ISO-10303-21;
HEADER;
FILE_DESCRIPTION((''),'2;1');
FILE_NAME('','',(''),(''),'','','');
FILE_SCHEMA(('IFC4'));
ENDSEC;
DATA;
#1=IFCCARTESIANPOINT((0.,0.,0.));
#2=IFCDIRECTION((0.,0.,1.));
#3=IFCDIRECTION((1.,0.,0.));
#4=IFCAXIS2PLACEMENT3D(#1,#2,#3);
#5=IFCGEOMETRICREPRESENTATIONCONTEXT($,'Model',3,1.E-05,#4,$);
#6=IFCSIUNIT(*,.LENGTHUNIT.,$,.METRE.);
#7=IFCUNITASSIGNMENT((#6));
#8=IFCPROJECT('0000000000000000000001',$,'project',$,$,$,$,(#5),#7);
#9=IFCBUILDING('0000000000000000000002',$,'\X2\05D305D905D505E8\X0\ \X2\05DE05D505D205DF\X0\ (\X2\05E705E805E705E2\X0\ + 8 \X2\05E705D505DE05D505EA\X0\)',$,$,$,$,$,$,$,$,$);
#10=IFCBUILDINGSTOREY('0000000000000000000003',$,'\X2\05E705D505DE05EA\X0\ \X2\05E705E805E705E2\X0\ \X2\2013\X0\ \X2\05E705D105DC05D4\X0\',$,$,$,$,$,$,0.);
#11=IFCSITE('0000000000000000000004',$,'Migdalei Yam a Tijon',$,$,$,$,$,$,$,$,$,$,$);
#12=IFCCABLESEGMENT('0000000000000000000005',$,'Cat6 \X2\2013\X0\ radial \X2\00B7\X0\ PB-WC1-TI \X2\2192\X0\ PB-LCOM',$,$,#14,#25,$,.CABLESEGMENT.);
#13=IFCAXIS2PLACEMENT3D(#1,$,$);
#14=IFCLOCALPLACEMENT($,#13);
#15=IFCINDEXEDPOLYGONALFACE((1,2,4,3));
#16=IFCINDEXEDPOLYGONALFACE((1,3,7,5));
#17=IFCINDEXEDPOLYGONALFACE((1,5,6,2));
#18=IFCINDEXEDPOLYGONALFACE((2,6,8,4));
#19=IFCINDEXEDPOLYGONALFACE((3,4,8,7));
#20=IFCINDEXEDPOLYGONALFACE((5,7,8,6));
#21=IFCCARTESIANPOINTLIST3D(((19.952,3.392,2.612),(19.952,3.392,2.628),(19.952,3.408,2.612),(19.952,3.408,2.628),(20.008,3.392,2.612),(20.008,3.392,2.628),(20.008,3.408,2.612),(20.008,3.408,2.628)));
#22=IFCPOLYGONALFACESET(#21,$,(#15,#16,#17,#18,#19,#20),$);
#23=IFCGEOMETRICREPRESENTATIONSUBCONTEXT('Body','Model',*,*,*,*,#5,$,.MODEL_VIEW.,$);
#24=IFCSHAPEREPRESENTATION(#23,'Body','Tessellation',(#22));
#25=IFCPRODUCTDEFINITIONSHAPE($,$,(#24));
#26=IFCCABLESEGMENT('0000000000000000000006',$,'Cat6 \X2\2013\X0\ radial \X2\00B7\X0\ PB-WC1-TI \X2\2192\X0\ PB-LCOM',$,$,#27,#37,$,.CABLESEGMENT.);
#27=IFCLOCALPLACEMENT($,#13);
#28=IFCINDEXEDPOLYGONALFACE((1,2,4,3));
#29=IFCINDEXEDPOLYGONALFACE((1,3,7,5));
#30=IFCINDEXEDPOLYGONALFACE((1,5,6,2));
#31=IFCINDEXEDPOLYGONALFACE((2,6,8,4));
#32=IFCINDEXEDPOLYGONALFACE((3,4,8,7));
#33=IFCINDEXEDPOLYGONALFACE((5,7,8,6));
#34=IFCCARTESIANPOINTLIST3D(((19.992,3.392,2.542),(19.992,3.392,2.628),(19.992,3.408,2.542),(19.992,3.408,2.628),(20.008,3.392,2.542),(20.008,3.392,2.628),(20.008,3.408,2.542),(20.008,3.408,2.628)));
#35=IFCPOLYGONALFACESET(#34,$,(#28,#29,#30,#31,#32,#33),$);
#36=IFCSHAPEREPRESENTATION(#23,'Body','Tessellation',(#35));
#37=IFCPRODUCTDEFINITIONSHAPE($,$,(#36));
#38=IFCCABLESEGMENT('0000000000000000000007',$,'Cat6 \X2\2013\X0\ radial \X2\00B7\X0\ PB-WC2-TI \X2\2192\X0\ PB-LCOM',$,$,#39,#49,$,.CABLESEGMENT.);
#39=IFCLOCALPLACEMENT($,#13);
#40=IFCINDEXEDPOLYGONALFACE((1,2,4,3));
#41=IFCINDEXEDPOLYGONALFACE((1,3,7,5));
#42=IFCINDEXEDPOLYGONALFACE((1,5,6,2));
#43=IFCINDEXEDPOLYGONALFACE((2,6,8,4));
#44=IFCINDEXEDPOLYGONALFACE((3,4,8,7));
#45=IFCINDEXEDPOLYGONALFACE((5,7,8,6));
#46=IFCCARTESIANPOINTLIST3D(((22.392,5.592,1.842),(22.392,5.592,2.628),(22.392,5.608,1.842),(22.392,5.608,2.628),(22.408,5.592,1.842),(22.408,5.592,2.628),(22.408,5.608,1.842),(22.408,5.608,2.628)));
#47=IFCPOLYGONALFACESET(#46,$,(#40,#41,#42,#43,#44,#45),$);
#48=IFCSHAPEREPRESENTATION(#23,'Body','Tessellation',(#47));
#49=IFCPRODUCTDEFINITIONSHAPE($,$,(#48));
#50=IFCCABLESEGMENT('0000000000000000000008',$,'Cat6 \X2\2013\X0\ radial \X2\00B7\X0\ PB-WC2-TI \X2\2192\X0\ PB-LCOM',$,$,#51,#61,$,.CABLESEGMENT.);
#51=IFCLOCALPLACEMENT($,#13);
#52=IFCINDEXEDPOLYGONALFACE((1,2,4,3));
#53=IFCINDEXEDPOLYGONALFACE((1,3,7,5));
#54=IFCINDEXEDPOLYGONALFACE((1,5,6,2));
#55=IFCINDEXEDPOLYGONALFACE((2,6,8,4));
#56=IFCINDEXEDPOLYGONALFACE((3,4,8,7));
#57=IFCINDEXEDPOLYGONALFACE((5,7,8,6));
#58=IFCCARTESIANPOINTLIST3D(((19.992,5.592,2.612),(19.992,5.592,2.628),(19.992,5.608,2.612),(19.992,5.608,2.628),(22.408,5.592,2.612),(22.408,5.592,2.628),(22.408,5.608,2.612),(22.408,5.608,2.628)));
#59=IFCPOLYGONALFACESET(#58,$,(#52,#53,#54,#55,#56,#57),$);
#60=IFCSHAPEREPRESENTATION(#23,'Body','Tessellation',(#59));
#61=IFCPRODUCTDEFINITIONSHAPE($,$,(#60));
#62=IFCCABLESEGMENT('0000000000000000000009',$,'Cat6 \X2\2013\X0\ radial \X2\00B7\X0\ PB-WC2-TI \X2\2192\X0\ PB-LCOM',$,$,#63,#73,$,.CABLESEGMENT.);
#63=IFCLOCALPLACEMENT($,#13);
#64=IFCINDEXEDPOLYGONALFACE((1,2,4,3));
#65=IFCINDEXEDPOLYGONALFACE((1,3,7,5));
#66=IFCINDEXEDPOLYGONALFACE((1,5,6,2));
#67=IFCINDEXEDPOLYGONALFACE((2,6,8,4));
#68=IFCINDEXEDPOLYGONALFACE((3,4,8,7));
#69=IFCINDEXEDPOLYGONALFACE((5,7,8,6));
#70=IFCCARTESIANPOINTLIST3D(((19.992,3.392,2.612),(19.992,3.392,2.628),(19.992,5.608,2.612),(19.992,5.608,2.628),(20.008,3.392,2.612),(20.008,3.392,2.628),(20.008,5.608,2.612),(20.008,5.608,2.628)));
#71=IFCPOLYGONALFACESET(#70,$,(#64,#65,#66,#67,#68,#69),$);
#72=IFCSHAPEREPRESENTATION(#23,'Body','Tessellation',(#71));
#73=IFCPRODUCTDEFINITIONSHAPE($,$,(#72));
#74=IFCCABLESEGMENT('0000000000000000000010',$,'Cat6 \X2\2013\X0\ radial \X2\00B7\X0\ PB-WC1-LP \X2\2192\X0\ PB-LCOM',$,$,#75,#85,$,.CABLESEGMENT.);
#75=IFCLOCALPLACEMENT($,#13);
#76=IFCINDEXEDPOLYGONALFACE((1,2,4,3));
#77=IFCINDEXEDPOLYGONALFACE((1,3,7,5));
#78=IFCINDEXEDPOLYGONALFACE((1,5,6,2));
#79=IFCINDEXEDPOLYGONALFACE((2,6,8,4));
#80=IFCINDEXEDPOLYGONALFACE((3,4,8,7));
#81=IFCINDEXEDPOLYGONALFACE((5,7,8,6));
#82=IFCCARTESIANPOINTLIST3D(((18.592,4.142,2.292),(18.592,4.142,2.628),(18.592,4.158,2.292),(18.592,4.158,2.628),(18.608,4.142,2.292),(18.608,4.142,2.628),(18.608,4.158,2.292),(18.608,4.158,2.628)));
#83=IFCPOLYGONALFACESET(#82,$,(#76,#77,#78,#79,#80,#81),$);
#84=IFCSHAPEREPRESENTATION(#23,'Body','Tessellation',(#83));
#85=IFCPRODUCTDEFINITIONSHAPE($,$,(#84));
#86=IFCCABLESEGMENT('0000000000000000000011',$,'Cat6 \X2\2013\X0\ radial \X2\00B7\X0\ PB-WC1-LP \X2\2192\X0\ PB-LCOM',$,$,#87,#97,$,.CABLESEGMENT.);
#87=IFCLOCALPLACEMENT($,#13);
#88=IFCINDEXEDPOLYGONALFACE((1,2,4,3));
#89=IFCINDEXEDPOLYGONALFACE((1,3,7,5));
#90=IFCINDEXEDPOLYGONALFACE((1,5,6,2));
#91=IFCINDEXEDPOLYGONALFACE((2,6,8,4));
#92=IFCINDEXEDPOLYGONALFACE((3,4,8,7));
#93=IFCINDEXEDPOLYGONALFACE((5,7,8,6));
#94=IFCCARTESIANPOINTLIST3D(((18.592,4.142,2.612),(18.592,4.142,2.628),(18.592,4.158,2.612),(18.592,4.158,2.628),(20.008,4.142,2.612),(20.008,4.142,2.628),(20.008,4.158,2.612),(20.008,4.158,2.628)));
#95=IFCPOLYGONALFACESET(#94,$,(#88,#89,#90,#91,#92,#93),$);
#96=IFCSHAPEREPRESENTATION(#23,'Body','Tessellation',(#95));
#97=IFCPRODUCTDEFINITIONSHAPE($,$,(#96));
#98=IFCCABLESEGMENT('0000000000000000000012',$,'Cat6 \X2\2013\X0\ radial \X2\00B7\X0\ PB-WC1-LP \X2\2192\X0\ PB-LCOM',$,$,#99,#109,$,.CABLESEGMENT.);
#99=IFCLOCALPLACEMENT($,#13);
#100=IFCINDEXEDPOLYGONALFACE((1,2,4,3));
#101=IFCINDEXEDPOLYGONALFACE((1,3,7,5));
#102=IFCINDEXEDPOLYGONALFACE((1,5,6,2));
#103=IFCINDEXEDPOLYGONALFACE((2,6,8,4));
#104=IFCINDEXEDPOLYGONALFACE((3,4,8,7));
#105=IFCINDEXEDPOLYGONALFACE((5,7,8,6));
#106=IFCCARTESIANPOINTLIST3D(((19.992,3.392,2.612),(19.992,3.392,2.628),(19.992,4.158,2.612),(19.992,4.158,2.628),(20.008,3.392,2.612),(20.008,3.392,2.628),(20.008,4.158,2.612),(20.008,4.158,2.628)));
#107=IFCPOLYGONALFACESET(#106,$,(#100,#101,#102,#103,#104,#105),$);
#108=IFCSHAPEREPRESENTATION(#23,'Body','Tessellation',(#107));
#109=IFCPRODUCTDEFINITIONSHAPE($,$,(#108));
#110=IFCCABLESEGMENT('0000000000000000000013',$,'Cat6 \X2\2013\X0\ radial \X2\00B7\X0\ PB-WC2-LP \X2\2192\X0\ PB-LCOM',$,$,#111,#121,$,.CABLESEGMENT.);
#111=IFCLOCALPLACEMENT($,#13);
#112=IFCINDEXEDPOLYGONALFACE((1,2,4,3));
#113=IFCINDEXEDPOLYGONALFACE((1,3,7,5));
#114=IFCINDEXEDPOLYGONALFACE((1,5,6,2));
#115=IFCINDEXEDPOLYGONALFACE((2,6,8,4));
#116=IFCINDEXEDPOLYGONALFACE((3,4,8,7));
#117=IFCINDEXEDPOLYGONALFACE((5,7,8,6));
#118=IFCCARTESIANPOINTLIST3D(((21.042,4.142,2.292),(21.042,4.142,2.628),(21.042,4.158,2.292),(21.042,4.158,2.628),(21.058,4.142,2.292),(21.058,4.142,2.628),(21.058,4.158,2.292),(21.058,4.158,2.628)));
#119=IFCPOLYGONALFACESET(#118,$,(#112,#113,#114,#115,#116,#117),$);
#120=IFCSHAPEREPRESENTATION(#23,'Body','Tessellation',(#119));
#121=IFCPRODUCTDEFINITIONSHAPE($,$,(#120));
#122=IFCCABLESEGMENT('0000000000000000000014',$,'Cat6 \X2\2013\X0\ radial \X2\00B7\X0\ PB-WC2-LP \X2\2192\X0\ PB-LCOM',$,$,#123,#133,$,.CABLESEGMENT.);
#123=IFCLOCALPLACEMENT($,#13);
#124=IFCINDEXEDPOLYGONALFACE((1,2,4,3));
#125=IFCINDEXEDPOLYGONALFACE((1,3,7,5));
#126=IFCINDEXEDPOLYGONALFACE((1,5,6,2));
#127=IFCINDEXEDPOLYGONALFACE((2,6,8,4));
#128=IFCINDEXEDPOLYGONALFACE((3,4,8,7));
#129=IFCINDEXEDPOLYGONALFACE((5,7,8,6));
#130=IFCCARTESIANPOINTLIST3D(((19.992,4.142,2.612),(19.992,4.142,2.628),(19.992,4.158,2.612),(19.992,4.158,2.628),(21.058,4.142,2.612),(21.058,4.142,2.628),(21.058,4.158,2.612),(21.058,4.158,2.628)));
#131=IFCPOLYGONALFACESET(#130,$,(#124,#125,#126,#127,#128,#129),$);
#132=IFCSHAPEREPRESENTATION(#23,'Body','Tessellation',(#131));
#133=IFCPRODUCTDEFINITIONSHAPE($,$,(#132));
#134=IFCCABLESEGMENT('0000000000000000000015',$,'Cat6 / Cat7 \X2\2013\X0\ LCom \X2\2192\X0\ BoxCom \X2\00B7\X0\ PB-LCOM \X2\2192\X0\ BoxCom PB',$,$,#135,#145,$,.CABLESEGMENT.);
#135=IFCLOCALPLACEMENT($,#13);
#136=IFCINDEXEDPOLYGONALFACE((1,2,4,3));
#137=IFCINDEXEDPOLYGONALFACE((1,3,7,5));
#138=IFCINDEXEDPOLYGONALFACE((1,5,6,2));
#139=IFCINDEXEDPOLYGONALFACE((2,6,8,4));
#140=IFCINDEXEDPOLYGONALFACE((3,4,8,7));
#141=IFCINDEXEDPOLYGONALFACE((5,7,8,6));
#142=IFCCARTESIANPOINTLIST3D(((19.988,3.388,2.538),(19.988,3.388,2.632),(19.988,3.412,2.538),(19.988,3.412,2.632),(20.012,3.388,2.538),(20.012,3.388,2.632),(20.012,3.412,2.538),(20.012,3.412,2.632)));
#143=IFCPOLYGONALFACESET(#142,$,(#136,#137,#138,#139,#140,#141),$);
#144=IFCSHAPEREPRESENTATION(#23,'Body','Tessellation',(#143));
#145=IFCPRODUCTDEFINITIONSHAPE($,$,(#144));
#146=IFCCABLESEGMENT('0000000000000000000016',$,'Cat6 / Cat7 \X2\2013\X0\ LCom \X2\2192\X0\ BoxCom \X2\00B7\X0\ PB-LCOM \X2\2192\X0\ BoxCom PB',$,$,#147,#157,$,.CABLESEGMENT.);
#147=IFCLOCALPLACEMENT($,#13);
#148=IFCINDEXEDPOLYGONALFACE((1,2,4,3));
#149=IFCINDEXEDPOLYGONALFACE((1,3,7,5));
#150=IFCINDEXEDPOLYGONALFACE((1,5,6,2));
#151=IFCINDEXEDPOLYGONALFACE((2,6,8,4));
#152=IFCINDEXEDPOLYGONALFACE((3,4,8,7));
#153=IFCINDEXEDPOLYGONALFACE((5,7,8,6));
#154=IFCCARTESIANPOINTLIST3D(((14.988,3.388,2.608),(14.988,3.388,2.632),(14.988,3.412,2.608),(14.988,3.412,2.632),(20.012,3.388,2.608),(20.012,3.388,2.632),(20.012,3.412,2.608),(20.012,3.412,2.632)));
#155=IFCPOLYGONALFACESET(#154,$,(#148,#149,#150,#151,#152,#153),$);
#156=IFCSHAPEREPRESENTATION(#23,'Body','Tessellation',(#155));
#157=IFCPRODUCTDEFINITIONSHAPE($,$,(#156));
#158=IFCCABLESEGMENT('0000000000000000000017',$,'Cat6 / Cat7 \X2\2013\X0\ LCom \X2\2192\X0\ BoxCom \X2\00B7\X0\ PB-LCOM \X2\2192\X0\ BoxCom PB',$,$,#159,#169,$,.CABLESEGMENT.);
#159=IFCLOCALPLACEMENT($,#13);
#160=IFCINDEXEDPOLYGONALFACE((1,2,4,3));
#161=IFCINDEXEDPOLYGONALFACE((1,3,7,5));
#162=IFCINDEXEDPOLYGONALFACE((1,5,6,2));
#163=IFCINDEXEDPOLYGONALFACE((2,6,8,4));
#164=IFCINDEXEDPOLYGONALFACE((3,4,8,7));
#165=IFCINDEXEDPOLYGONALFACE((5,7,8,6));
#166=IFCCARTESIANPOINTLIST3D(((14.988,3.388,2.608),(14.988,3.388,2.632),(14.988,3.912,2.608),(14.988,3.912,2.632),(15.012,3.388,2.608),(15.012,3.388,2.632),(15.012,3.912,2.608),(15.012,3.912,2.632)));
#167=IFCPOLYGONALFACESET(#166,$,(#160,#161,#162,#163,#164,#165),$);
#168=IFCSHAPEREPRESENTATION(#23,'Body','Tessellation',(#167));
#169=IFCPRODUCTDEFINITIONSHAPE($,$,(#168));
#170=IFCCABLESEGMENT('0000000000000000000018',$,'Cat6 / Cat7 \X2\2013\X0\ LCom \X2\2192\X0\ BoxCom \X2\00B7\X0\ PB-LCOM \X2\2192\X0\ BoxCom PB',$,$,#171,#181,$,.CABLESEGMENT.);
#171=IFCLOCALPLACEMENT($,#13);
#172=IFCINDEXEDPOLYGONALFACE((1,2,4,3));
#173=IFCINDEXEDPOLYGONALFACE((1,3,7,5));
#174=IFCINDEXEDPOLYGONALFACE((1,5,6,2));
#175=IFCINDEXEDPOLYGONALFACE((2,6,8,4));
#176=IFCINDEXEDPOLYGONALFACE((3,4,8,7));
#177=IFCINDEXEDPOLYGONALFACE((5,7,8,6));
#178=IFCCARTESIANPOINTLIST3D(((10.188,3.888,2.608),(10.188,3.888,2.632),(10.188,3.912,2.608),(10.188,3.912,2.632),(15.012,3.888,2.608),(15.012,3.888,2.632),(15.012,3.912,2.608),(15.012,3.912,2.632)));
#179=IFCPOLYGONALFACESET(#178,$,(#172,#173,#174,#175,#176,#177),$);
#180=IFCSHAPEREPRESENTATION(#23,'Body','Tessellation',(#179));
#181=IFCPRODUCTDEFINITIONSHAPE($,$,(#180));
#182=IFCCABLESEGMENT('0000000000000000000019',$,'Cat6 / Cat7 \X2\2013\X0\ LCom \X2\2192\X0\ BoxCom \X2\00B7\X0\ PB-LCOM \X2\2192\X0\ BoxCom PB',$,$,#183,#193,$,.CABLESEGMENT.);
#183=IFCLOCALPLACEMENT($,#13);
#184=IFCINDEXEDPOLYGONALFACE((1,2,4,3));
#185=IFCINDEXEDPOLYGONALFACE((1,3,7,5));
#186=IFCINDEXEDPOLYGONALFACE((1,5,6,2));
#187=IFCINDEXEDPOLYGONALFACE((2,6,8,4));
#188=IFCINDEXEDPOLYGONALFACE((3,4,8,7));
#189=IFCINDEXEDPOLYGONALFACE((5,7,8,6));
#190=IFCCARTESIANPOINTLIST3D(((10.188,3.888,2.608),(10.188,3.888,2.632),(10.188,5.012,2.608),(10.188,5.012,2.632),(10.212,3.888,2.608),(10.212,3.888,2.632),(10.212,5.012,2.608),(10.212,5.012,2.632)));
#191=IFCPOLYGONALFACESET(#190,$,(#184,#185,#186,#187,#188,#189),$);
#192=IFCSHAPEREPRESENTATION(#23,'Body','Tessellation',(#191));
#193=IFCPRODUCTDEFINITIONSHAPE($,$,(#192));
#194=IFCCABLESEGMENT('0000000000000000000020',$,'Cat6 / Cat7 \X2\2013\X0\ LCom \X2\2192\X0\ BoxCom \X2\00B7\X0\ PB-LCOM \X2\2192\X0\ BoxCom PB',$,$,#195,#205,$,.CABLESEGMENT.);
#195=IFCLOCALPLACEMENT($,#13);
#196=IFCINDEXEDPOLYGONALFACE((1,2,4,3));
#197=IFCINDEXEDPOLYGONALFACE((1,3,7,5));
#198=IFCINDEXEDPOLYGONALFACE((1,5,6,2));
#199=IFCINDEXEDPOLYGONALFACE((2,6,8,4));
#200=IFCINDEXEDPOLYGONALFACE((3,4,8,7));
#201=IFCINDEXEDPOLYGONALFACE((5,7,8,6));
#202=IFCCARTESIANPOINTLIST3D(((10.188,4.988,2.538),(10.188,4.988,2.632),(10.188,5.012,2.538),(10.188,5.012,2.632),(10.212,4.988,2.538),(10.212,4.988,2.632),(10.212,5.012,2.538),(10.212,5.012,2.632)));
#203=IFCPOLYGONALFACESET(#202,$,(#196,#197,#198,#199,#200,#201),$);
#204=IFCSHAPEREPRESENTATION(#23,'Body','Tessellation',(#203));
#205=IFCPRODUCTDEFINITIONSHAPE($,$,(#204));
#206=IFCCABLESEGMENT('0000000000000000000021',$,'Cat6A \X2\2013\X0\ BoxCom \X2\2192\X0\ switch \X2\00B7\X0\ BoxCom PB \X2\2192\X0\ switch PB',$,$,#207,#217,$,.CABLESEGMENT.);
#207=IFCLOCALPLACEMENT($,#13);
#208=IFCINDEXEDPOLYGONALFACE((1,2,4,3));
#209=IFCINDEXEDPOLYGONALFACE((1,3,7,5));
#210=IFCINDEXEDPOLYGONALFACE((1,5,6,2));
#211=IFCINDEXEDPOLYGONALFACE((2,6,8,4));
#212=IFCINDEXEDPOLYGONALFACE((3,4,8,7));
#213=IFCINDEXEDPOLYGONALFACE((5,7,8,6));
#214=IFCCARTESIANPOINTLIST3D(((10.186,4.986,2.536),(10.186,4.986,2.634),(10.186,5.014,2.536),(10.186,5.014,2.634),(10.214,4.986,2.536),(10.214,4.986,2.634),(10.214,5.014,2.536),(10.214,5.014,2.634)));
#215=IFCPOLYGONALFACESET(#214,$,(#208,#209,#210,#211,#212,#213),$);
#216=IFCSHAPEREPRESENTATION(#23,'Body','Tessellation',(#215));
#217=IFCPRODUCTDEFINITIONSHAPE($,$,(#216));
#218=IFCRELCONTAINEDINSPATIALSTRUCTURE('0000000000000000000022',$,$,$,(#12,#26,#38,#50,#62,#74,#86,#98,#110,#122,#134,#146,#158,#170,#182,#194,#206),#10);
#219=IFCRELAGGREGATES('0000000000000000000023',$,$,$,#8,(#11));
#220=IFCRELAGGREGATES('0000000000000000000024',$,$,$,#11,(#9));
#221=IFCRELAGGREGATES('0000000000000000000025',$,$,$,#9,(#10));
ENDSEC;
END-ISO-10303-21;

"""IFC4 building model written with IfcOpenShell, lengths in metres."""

from ifc_helpers import new_model, si_unit, frame, origin_with_axes, context, subcontext, project, spatial, line, indexed_curve, outline, extrude, element, save


model = new_model("IFC4")

# Units and contexts
model_context = context("Model", 3, precision=1e-05, world=origin_with_axes())
body_context = subcontext(model_context, "Body", "Model", "MODEL_VIEW")
ifc_project = project(units=[si_unit("LENGTHUNIT", "METRE")], contexts=[model_context])

# Site, building, storey
site = spatial("IfcSite", under=ifc_project, Name="Migdalei Yam a Tijon")
building = spatial("IfcBuilding", under=site, Name="דיור מוגן (קרקע + 8 קומות)")
storey = spatial("IfcBuildingStorey", under=building, Name="קומת קרקע – קבלה", Elevation=0.0)

# Cable segments
element("IfcCableSegment", 1, inside=storey, Name="Cat6 – radial · PB-WC1-TI → PB-LCOM", PredefinedType="CABLESEGMENT", context=body_context, shape_type="SweptSolid", body=[
    extrude(outline(indexed_curve([(0.0, 0.0), (0.056, 0.0), (0.056, 0.016), (0.0, 0.016)], segments=[line(1, 2, 3, 4, 1)])), frame((19.952, 3.392, 2.612), z_axis=(0.0, 0.0, 1.0), x_axis=(1.0, 0.0, 0.0)), (0.0, 0.0, 1.0), 0.016),
])
element("IfcCableSegment", 2, inside=storey, Name="Cat6 – radial · PB-WC1-TI → PB-LCOM", PredefinedType="CABLESEGMENT", context=body_context, shape_type="SweptSolid", body=[
    extrude(outline(indexed_curve([(0.0, 0.0), (0.016, 0.0), (0.016, 0.016), (0.0, 0.016)], segments=[line(1, 2, 3, 4, 1)])), frame((19.992, 3.392, 2.542), z_axis=(0.0, 0.0, 1.0), x_axis=(1.0, 0.0, 0.0)), (0.0, 0.0, 1.0), 0.086),
])
element("IfcCableSegment", 3, inside=storey, Name="Cat6 – radial · PB-WC2-TI → PB-LCOM", PredefinedType="CABLESEGMENT", context=body_context, shape_type="SweptSolid", body=[
    extrude(outline(indexed_curve([(0.0, 0.0), (0.016, 0.0), (0.016, 0.016), (0.0, 0.016)], segments=[line(1, 2, 3, 4, 1)])), frame((22.392, 5.592, 1.842), z_axis=(0.0, 0.0, 1.0), x_axis=(1.0, 0.0, 0.0)), (0.0, 0.0, 1.0), 0.786),
])
element("IfcCableSegment", 4, inside=storey, Name="Cat6 – radial · PB-WC2-TI → PB-LCOM", PredefinedType="CABLESEGMENT", context=body_context, shape_type="SweptSolid", body=[
    extrude(outline(indexed_curve([(0.0, 0.0), (2.416, 0.0), (2.416, 0.016), (0.0, 0.016)], segments=[line(1, 2, 3, 4, 1)])), frame((19.992, 5.592, 2.612), z_axis=(0.0, 0.0, 1.0), x_axis=(1.0, 0.0, 0.0)), (0.0, 0.0, 1.0), 0.016),
])
element("IfcCableSegment", 5, inside=storey, Name="Cat6 – radial · PB-WC2-TI → PB-LCOM", PredefinedType="CABLESEGMENT", context=body_context, shape_type="SweptSolid", body=[
    extrude(outline(indexed_curve([(0.0, 0.0), (0.016, 0.0), (0.016, 2.216), (0.0, 2.216)], segments=[line(1, 2, 3, 4, 1)])), frame((19.992, 3.392, 2.612), z_axis=(0.0, 0.0, 1.0), x_axis=(1.0, 0.0, 0.0)), (0.0, 0.0, 1.0), 0.016),
])
element("IfcCableSegment", 6, inside=storey, Name="Cat6 – radial · PB-WC1-LP → PB-LCOM", PredefinedType="CABLESEGMENT", context=body_context, shape_type="SweptSolid", body=[
    extrude(outline(indexed_curve([(0.0, 0.0), (0.016, 0.0), (0.016, 0.016), (0.0, 0.016)], segments=[line(1, 2, 3, 4, 1)])), frame((18.592, 4.142, 2.292), z_axis=(0.0, 0.0, 1.0), x_axis=(1.0, 0.0, 0.0)), (0.0, 0.0, 1.0), 0.336),
])
element("IfcCableSegment", 7, inside=storey, Name="Cat6 – radial · PB-WC1-LP → PB-LCOM", PredefinedType="CABLESEGMENT", context=body_context, shape_type="SweptSolid", body=[
    extrude(outline(indexed_curve([(0.0, 0.0), (1.416, 0.0), (1.416, 0.016), (0.0, 0.016)], segments=[line(1, 2, 3, 4, 1)])), frame((18.592, 4.142, 2.612), z_axis=(0.0, 0.0, 1.0), x_axis=(1.0, 0.0, 0.0)), (0.0, 0.0, 1.0), 0.016),
])
element("IfcCableSegment", 8, inside=storey, Name="Cat6 – radial · PB-WC1-LP → PB-LCOM", PredefinedType="CABLESEGMENT", context=body_context, shape_type="SweptSolid", body=[
    extrude(outline(indexed_curve([(0.0, 0.0), (0.016, 0.0), (0.016, 0.766), (0.0, 0.766)], segments=[line(1, 2, 3, 4, 1)])), frame((19.992, 3.392, 2.612), z_axis=(0.0, 0.0, 1.0), x_axis=(1.0, 0.0, 0.0)), (0.0, 0.0, 1.0), 0.016),
])
element("IfcCableSegment", 9, inside=storey, Name="Cat6 – radial · PB-WC2-LP → PB-LCOM", PredefinedType="CABLESEGMENT", context=body_context, shape_type="SweptSolid", body=[
    extrude(outline(indexed_curve([(0.0, 0.0), (0.016, 0.0), (0.016, 0.016), (0.0, 0.016)], segments=[line(1, 2, 3, 4, 1)])), frame((21.042, 4.142, 2.292), z_axis=(0.0, 0.0, 1.0), x_axis=(1.0, 0.0, 0.0)), (0.0, 0.0, 1.0), 0.336),
])
element("IfcCableSegment", 10, inside=storey, Name="Cat6 – radial · PB-WC2-LP → PB-LCOM", PredefinedType="CABLESEGMENT", context=body_context, shape_type="SweptSolid", body=[
    extrude(outline(indexed_curve([(0.0, 0.0), (1.066, 0.0), (1.066, 0.016), (0.0, 0.016)], segments=[line(1, 2, 3, 4, 1)])), frame((19.992, 4.142, 2.612), z_axis=(0.0, 0.0, 1.0), x_axis=(1.0, 0.0, 0.0)), (0.0, 0.0, 1.0), 0.016),
])
element("IfcCableSegment", 11, inside=storey, Name="Cat6 / Cat7 – LCom → BoxCom · PB-LCOM → BoxCom PB", PredefinedType="CABLESEGMENT", context=body_context, shape_type="SweptSolid", body=[
    extrude(outline(indexed_curve([(0.0, 0.0), (0.024, 0.0), (0.024, 0.024), (0.0, 0.024)], segments=[line(1, 2, 3, 4, 1)])), frame((19.988, 3.388, 2.538), z_axis=(0.0, 0.0, 1.0), x_axis=(1.0, 0.0, 0.0)), (0.0, 0.0, 1.0), 0.094),
])
element("IfcCableSegment", 12, inside=storey, Name="Cat6 / Cat7 – LCom → BoxCom · PB-LCOM → BoxCom PB", PredefinedType="CABLESEGMENT", context=body_context, shape_type="SweptSolid", body=[
    extrude(outline(indexed_curve([(0.0, 0.0), (5.024, 0.0), (5.024, 0.024), (0.0, 0.024)], segments=[line(1, 2, 3, 4, 1)])), frame((14.988, 3.388, 2.608), z_axis=(0.0, 0.0, 1.0), x_axis=(1.0, 0.0, 0.0)), (0.0, 0.0, 1.0), 0.024),
])
element("IfcCableSegment", 13, inside=storey, Name="Cat6 / Cat7 – LCom → BoxCom · PB-LCOM → BoxCom PB", PredefinedType="CABLESEGMENT", context=body_context, shape_type="SweptSolid", body=[
    extrude(outline(indexed_curve([(0.0, 0.0), (0.024, 0.0), (0.024, 0.524), (0.0, 0.524)], segments=[line(1, 2, 3, 4, 1)])), frame((14.988, 3.388, 2.608), z_axis=(0.0, 0.0, 1.0), x_axis=(1.0, 0.0, 0.0)), (0.0, 0.0, 1.0), 0.024),
])
element("IfcCableSegment", 14, inside=storey, Name="Cat6 / Cat7 – LCom → BoxCom · PB-LCOM → BoxCom PB", PredefinedType="CABLESEGMENT", context=body_context, shape_type="SweptSolid", body=[
    extrude(outline(indexed_curve([(0.0, 0.0), (4.824, 0.0), (4.824, 0.024), (0.0, 0.024)], segments=[line(1, 2, 3, 4, 1)])), frame((10.188, 3.888, 2.608), z_axis=(0.0, 0.0, 1.0), x_axis=(1.0, 0.0, 0.0)), (0.0, 0.0, 1.0), 0.024),
])
element("IfcCableSegment", 15, inside=storey, Name="Cat6 / Cat7 – LCom → BoxCom · PB-LCOM → BoxCom PB", PredefinedType="CABLESEGMENT", context=body_context, shape_type="SweptSolid", body=[
    extrude(outline(indexed_curve([(0.0, 0.0), (0.024, 0.0), (0.024, 1.124), (0.0, 1.124)], segments=[line(1, 2, 3, 4, 1)])), frame((10.188, 3.888, 2.608), z_axis=(0.0, 0.0, 1.0), x_axis=(1.0, 0.0, 0.0)), (0.0, 0.0, 1.0), 0.024),
])
element("IfcCableSegment", 16, inside=storey, Name="Cat6 / Cat7 – LCom → BoxCom · PB-LCOM → BoxCom PB", PredefinedType="CABLESEGMENT", context=body_context, shape_type="SweptSolid", body=[
    extrude(outline(indexed_curve([(0.0, 0.0), (0.024, 0.0), (0.024, 0.024), (0.0, 0.024)], segments=[line(1, 2, 3, 4, 1)])), frame((10.188, 4.988, 2.538), z_axis=(0.0, 0.0, 1.0), x_axis=(1.0, 0.0, 0.0)), (0.0, 0.0, 1.0), 0.094),
])
element("IfcCableSegment", 17, inside=storey, Name="Cat6A – BoxCom → switch · BoxCom PB → switch PB", PredefinedType="CABLESEGMENT", context=body_context, shape_type="SweptSolid", body=[
    extrude(outline(indexed_curve([(0.0, 0.0), (0.028, 0.0), (0.028, 0.028), (0.0, 0.028)], segments=[line(1, 2, 3, 4, 1)])), frame((10.186, 4.986, 2.536), z_axis=(0.0, 0.0, 1.0), x_axis=(1.0, 0.0, 0.0)), (0.0, 0.0, 1.0), 0.098),
])

save(model, "model.ifc")
